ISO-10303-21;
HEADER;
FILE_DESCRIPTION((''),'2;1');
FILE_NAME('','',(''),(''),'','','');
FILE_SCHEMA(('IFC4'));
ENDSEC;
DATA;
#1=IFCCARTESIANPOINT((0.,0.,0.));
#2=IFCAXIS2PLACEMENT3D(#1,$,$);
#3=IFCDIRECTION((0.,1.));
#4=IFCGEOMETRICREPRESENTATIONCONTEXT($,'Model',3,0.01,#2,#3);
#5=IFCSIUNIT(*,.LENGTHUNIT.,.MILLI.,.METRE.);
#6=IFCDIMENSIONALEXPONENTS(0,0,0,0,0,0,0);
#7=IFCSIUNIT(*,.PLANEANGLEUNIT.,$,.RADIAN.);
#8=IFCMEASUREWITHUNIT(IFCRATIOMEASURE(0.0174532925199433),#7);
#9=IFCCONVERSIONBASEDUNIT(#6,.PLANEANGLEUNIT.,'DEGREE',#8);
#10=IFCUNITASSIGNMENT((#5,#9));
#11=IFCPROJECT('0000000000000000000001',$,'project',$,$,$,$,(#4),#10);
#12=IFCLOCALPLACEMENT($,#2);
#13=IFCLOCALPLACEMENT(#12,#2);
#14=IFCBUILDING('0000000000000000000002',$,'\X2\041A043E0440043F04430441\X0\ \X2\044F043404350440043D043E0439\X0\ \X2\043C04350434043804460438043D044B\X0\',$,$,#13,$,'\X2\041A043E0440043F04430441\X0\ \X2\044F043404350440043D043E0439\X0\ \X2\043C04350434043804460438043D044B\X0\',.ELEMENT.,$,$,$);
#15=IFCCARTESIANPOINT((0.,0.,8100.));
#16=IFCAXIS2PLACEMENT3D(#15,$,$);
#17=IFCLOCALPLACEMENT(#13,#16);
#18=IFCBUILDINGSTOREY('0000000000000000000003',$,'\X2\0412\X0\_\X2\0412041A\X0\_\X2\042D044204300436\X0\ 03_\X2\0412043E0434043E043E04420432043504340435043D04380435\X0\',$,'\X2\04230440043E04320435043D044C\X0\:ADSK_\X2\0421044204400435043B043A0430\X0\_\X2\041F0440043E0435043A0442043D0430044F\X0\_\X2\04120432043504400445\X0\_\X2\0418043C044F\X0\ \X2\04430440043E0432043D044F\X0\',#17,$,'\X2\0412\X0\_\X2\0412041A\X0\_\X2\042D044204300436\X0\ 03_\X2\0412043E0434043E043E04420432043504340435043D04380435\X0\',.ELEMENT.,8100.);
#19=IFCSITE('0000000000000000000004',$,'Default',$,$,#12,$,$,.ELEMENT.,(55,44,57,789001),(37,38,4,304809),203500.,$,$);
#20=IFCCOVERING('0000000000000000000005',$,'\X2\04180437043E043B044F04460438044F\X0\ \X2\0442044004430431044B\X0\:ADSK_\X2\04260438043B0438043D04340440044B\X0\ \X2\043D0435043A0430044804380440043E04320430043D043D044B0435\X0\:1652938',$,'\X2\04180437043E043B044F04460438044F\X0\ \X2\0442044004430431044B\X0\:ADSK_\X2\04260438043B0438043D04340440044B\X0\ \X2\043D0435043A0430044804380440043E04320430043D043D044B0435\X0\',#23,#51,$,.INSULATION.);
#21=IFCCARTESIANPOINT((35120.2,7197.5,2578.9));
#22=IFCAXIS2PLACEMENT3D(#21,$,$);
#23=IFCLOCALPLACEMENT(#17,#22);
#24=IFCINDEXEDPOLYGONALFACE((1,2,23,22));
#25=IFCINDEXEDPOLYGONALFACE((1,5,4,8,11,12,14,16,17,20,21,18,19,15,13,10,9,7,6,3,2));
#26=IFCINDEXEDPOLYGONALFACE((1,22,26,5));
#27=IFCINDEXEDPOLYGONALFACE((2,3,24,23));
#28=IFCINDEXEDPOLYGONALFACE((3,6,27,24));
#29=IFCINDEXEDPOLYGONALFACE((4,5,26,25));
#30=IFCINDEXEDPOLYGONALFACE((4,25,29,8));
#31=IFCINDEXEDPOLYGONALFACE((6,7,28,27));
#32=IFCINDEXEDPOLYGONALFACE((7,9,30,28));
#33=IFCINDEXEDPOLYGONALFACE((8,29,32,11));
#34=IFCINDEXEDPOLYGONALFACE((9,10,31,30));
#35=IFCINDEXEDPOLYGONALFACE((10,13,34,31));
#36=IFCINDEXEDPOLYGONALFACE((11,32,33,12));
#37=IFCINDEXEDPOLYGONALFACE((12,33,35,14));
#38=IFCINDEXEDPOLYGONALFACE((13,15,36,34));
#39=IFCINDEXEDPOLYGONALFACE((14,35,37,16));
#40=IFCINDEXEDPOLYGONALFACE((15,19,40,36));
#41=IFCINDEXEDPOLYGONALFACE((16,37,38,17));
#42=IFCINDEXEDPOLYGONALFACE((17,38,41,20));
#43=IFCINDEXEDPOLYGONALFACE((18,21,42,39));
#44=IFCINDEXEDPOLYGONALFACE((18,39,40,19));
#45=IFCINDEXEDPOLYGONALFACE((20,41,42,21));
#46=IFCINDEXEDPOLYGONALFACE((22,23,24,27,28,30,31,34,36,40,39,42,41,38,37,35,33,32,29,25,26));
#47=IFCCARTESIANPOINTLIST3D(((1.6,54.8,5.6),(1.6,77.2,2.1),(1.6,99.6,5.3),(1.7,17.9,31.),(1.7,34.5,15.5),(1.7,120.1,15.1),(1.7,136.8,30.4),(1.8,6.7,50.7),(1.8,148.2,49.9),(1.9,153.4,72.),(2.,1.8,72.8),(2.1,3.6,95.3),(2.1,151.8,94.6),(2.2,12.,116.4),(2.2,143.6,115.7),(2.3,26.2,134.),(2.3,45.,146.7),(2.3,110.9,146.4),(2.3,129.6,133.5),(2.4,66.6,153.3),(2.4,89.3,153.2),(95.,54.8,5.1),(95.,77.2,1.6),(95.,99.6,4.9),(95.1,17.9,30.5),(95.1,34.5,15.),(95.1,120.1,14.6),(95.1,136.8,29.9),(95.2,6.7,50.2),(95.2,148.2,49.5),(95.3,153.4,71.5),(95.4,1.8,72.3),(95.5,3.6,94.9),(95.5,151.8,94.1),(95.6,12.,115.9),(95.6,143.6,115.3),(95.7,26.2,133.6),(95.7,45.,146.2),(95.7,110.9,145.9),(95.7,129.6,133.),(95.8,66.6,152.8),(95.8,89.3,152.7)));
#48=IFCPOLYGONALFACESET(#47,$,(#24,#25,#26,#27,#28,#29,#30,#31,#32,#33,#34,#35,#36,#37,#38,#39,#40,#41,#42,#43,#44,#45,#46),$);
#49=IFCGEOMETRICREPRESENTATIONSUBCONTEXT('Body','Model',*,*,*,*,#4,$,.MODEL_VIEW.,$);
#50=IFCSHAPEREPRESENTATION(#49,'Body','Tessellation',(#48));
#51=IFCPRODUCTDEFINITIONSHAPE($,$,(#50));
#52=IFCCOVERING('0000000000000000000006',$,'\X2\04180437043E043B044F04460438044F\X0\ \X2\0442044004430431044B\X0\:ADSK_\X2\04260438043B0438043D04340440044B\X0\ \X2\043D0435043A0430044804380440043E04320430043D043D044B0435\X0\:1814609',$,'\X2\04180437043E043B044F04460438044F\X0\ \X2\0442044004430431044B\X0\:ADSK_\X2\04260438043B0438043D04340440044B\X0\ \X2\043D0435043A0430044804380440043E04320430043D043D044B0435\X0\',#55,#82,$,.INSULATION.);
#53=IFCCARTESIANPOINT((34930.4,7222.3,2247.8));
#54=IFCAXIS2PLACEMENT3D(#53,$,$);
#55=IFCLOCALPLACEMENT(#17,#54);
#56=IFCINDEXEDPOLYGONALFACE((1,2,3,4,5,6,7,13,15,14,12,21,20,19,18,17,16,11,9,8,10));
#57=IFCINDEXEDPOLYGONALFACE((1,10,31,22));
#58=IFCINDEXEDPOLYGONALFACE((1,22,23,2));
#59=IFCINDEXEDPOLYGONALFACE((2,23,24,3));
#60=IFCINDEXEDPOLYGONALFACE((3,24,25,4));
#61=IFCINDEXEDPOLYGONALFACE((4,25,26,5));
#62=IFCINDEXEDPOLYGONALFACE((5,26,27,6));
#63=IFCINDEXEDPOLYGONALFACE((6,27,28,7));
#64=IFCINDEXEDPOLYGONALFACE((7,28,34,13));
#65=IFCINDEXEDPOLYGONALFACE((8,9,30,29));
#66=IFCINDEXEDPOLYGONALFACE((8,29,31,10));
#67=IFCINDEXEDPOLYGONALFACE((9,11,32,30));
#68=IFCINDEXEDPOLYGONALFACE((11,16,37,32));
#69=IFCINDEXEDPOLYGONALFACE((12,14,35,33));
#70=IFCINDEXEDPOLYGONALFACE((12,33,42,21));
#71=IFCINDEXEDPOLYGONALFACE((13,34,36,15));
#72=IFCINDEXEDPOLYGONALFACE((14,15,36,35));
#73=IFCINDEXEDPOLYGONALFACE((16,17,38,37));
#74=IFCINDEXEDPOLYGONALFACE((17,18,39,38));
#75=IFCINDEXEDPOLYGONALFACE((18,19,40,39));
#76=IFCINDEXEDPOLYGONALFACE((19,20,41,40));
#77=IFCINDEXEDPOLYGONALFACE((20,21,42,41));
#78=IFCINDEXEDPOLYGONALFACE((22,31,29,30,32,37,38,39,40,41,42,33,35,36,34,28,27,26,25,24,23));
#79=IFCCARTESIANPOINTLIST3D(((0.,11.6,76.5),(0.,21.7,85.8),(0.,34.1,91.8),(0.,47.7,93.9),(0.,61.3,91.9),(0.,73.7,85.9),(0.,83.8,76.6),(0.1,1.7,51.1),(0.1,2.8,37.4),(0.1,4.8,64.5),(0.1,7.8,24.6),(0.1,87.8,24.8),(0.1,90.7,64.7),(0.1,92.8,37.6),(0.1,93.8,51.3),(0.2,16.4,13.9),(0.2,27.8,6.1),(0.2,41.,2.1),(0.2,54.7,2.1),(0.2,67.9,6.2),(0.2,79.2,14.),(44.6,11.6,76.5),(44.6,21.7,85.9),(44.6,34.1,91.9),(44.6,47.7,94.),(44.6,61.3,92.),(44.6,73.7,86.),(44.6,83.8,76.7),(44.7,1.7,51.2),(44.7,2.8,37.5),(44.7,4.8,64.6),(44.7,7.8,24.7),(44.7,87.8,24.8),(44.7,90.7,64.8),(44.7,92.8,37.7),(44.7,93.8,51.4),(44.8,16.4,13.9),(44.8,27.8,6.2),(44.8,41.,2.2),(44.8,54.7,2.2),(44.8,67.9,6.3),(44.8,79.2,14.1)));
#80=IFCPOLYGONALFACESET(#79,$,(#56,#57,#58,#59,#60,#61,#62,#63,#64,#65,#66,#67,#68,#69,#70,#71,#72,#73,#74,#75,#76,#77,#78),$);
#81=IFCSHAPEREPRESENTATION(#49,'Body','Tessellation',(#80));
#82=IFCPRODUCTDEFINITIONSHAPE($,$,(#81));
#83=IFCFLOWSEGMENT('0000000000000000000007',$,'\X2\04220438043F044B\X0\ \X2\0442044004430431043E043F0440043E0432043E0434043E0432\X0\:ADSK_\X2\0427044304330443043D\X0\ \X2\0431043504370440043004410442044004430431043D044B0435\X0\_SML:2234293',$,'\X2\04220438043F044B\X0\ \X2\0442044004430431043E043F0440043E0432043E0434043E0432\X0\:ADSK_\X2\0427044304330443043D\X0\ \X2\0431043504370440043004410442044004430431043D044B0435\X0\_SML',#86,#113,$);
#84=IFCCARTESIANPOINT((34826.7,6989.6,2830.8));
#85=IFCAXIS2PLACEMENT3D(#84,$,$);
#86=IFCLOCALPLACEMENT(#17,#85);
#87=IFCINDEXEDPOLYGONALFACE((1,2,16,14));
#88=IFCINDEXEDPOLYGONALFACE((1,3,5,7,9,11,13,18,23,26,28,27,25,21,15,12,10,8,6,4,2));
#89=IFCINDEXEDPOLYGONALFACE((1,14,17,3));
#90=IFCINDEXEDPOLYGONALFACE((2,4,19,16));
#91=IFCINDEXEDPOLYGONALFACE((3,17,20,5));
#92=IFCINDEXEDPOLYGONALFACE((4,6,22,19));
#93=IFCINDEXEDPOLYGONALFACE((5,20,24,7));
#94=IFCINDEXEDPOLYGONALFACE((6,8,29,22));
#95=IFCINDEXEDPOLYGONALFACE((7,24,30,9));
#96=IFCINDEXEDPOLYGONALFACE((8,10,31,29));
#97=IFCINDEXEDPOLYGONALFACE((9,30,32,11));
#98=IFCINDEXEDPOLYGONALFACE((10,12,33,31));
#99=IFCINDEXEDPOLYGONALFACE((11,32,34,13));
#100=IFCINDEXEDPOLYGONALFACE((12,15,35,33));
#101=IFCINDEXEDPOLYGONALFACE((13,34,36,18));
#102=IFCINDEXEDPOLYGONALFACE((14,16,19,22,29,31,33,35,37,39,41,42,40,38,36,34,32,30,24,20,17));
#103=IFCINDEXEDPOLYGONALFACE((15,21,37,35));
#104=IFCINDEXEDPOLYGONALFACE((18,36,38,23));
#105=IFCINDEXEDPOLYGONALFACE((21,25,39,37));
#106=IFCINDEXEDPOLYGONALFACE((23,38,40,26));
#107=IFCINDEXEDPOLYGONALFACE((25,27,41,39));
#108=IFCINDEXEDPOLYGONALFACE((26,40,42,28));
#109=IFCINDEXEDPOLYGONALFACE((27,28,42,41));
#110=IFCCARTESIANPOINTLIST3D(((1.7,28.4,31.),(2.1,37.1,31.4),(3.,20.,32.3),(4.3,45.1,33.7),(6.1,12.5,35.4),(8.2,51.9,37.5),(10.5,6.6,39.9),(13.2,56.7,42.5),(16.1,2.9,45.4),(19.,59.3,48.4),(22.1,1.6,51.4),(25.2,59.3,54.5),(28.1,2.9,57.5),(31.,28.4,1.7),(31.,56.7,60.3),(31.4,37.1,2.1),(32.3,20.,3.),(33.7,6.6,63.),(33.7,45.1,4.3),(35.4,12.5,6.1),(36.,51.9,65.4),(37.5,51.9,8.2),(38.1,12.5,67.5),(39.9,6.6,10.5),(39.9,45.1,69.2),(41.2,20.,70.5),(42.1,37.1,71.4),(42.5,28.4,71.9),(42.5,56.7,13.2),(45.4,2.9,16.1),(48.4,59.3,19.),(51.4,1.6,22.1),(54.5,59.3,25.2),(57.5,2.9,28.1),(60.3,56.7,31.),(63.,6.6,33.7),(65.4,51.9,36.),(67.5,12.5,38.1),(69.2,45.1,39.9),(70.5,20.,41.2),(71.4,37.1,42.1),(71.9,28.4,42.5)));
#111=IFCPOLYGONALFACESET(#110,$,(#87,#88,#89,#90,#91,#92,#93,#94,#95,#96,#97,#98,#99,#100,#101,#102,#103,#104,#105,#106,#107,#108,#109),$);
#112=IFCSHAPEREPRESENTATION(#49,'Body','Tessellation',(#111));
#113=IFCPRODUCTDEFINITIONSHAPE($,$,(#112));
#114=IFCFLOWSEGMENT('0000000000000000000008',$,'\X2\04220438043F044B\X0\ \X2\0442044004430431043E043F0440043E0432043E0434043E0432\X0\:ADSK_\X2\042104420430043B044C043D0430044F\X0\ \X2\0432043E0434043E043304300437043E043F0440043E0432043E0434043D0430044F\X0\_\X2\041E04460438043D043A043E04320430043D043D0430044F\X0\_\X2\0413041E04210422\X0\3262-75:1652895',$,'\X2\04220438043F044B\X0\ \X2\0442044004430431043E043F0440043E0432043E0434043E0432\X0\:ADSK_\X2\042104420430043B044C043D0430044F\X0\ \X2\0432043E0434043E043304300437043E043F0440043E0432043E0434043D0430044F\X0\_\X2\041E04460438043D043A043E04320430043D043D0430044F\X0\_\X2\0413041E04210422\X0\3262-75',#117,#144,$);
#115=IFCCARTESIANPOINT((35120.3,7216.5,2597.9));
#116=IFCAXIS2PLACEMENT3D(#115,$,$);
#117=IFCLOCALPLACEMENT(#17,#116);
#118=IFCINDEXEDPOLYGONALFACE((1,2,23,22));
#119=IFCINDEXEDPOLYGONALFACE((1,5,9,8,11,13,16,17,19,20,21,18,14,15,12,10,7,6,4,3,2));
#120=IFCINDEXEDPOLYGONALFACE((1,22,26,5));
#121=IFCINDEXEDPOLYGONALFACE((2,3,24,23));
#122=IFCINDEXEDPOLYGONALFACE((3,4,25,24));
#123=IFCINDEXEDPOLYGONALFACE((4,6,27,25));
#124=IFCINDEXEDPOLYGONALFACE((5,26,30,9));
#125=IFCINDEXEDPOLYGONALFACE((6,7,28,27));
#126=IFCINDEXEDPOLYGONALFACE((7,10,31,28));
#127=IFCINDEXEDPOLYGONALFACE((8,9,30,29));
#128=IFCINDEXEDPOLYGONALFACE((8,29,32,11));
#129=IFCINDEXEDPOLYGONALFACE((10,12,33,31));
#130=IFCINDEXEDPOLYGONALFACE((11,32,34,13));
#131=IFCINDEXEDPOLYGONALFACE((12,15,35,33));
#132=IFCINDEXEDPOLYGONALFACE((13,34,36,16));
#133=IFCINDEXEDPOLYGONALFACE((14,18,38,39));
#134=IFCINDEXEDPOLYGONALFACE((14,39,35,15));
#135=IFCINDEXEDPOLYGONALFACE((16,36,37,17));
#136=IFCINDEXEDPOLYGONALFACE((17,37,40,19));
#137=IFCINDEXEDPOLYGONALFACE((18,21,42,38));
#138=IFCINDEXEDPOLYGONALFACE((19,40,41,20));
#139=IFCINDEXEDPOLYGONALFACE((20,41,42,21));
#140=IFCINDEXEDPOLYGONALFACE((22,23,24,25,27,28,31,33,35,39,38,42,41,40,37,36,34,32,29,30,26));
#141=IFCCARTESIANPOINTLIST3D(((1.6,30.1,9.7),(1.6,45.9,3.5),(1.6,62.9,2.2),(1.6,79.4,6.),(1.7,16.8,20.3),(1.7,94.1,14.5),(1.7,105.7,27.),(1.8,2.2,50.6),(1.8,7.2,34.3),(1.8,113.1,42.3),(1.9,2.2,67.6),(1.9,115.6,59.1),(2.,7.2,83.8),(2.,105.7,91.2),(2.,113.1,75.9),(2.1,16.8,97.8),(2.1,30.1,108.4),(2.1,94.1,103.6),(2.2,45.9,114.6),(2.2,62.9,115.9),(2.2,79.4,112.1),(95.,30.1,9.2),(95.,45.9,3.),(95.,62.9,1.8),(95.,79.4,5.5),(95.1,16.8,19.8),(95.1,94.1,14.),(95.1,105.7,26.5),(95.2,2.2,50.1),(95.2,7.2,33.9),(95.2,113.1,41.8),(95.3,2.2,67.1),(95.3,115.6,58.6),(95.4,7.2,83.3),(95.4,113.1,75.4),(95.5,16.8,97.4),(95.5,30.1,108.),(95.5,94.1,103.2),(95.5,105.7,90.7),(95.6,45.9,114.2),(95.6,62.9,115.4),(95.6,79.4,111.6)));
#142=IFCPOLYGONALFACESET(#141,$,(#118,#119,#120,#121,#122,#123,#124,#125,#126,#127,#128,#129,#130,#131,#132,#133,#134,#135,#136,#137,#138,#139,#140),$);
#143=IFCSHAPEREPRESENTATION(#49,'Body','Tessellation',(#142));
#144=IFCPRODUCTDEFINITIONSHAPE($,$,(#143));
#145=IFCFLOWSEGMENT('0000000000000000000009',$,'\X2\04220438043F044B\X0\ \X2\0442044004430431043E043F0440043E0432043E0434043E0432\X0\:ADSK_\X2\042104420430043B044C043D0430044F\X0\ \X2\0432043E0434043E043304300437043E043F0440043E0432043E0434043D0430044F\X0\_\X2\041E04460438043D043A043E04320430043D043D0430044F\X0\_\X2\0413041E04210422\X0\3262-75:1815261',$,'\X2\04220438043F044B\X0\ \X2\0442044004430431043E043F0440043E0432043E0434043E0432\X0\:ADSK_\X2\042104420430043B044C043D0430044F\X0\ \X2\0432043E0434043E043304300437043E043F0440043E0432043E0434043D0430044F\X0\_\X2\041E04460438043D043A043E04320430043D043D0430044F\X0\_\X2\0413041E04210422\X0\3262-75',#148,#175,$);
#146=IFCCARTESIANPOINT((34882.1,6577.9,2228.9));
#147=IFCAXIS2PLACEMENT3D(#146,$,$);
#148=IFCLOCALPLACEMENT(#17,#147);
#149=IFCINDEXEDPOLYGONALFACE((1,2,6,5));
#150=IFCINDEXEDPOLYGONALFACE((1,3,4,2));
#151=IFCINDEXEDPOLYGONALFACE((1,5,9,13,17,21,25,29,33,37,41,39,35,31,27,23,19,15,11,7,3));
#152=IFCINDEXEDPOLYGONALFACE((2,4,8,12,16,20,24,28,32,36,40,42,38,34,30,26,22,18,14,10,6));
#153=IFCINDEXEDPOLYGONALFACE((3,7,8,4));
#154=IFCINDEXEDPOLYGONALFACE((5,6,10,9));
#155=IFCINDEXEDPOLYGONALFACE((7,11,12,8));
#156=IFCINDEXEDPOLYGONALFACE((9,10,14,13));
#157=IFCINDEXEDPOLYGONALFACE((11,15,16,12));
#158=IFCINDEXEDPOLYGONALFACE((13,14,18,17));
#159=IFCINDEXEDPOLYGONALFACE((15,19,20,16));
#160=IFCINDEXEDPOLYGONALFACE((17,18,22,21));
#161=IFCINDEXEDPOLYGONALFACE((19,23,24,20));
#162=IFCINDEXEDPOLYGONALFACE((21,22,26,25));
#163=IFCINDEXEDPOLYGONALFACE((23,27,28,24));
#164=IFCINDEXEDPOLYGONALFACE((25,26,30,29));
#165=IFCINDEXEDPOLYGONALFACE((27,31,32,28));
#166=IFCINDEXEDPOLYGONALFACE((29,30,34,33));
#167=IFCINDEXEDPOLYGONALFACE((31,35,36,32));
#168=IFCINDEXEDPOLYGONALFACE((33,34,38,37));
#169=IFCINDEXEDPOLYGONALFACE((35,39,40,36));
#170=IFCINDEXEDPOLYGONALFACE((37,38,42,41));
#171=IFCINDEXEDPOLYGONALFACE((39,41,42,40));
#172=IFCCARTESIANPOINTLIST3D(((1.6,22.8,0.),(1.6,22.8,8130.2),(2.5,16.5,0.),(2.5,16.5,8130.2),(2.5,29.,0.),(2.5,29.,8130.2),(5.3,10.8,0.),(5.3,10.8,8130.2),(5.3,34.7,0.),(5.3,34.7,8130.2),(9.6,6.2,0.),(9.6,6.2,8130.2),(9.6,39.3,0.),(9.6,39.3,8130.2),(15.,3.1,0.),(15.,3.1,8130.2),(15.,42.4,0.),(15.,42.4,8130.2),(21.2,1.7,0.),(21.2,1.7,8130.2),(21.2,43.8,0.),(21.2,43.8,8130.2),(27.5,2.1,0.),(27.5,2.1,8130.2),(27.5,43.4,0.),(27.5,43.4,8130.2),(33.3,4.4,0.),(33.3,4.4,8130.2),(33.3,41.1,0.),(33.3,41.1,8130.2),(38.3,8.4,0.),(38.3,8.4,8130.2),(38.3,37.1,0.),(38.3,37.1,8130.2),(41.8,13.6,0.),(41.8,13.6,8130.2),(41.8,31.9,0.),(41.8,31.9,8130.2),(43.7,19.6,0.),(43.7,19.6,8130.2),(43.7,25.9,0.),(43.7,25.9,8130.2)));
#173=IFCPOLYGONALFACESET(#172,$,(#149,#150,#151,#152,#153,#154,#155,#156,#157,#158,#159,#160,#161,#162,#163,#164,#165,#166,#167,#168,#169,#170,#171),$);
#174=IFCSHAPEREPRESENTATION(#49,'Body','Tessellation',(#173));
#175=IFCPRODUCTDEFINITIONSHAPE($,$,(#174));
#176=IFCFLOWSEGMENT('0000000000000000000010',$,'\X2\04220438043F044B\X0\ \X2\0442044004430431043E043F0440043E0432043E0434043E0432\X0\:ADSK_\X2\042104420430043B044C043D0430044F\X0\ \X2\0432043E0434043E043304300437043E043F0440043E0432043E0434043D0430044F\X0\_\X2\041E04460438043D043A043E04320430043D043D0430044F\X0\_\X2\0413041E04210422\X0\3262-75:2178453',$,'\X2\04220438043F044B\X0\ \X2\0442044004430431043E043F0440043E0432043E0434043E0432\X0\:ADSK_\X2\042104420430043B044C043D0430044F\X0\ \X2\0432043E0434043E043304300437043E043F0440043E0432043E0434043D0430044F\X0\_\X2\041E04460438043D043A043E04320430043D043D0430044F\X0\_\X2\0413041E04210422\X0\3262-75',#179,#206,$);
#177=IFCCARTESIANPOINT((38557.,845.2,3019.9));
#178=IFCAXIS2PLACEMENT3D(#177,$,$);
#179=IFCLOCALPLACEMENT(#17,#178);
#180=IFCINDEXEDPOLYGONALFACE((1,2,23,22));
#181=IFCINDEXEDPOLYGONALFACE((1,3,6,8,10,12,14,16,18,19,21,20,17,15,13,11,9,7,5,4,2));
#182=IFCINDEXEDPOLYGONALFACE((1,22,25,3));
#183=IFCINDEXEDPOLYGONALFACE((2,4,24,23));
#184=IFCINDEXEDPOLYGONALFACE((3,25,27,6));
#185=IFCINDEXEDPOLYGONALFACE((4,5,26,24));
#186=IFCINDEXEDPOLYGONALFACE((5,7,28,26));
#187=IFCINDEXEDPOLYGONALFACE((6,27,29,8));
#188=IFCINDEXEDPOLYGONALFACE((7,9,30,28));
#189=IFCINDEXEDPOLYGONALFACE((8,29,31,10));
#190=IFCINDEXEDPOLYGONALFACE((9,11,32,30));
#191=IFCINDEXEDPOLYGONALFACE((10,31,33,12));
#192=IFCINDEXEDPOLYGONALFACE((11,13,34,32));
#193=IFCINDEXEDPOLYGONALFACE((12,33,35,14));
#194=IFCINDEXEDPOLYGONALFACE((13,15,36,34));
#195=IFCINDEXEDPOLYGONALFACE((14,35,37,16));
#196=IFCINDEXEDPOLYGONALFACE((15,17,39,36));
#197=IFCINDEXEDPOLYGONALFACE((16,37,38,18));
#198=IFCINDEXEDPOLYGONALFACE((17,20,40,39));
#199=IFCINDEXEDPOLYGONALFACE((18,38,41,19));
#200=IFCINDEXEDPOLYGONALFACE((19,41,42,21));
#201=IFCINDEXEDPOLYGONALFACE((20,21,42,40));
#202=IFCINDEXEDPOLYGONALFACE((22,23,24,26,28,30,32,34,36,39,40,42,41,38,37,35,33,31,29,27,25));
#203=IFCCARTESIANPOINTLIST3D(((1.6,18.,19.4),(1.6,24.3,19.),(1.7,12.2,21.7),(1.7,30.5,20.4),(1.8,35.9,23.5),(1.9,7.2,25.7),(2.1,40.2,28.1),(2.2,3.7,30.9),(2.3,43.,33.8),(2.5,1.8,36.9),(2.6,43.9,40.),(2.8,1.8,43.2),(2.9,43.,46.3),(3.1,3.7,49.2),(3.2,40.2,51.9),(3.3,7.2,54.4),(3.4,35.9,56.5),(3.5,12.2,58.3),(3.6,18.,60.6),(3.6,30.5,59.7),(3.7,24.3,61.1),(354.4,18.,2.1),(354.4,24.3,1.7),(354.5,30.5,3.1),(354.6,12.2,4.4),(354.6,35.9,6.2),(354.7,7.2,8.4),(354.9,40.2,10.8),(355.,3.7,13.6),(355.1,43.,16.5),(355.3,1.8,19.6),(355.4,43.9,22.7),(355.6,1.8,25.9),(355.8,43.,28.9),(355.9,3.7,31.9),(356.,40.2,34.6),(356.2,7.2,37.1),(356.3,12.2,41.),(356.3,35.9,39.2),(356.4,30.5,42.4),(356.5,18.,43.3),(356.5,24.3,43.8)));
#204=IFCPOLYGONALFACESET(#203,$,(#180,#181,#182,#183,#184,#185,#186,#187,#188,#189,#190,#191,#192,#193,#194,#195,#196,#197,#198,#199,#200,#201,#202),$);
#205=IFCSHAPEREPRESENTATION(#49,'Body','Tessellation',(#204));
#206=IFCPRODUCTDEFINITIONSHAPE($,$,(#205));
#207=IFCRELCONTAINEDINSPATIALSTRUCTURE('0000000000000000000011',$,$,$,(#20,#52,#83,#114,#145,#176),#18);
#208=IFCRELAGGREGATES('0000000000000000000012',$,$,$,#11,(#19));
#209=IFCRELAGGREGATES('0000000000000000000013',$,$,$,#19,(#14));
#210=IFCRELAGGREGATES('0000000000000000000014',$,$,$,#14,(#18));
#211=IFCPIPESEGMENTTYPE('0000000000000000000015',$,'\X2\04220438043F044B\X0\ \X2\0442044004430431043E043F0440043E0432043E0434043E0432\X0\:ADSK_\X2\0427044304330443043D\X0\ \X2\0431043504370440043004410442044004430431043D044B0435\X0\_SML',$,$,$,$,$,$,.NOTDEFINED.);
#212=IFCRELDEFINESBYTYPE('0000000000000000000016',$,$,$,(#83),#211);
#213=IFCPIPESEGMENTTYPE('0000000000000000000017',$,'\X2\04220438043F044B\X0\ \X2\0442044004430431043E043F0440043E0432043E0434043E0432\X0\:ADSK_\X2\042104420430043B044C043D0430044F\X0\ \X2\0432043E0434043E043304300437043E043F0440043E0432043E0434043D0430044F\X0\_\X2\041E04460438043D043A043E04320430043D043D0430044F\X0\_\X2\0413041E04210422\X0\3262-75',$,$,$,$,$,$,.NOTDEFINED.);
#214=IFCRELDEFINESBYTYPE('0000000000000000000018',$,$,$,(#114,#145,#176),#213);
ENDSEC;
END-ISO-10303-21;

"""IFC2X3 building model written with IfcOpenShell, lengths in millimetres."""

from ifc_helpers import new_model, entity, si_unit, converted_unit, direction, frame, origin, origin_2d_with_axis, place, context, subcontext, project, spatial, circle, extrude, type_object, element, save


model = new_model("IFC2X3")

# Units and contexts
model_context = context("Model", 3, precision=0.01, world=origin(), true_north=direction((0.0, 1.0)))
body_context = subcontext(model_context, "Body", "Model", "MODEL_VIEW")
ifc_project = project(units=[si_unit("LENGTHUNIT", "METRE", prefix="MILLI"), converted_unit("PLANEANGLEUNIT", "DEGREE", entity("IfcRatioMeasure", 0.0174532925199433), si_unit("PLANEANGLEUNIT", "RADIAN"), dimensions=[0, 0, 0, 0, 0, 0, 0])], contexts=[model_context])

# Site, building, storey
site_placement = place(None, origin())
site = spatial("IfcSite", under=ifc_project, at=site_placement, Name="Default", CompositionType="ELEMENT", RefLatitude=(55, 44, 57, 789001), RefLongitude=(37, 38, 4, 304809), RefElevation=203500.0)
building_placement = place(site_placement, origin())
building = spatial("IfcBuilding", under=site, at=building_placement, Name="Корпус ядерной медицины", LongName="Корпус ядерной медицины", CompositionType="ELEMENT")
storey_placement = place(building_placement, frame((0.0, 0.0, 8100.0)))
storey = spatial("IfcBuildingStorey", under=building, at=storey_placement, Name="В_ВК_Этаж 03_Водоотведение", ObjectType="Уровень:ADSK_Стрелка_Проектная_Вверх_Имя уровня", LongName="В_ВК_Этаж 03_Водоотведение", CompositionType="ELEMENT", Elevation=8100.0)

# Coverings
covering_1_placement = place(storey_placement, frame((35120.2, 7197.5, 2578.9)))
element("IfcCovering", 1, at=covering_1_placement, inside=storey, Name="Изоляция трубы:ADSK_Цилиндры некашированные:1652938", ObjectType="Изоляция трубы:ADSK_Цилиндры некашированные", PredefinedType="INSULATION", context=body_context, shape_type="SweptSolid", body=[
    extrude(circle(Radius=76.0, at=origin_2d_with_axis()), frame((95.4, 77.6, 77.6), z_axis=(-0.999987, -0.000008, 0.005077), x_axis=(-0.005077, -0.005, -0.999975)), (0.0, 0.0, 1.0), 93.4),
])
covering_2_placement = place(storey_placement, frame((34930.4, 7222.3, 2247.8)))
element("IfcCovering", 2, at=covering_2_placement, inside=storey, Name="Изоляция трубы:ADSK_Цилиндры некашированные:1814609", ObjectType="Изоляция трубы:ADSK_Цилиндры некашированные", PredefinedType="INSULATION", context=body_context, shape_type="SweptSolid", body=[
    extrude(circle(Radius=46.1, at=origin_2d_with_axis()), frame((0.1, 47.8, 47.8), z_axis=(0.999998, 0.0, 0.002), x_axis=(-0.002, -0.002, 0.999996)), (0.0, 0.0, 1.0), 44.6),
])

# Flow segments
pipe_segment_type_1 = type_object("IfcPipeSegmentType", Name="Типы трубопроводов:ADSK_Чугун безраструбные_SML", PredefinedType="NOTDEFINED")
flow_segment_1_placement = place(storey_placement, frame((34826.7, 6989.6, 2830.8)))
element("IfcFlowSegment", 3, at=flow_segment_1_placement, inside=storey, type_object=pipe_segment_type_1, Name="Типы трубопроводов:ADSK_Чугун безраструбные_SML:2234293", ObjectType="Типы трубопроводов:ADSK_Чугун безраструбные_SML", context=body_context, shape_type="SweptSolid", body=[
    extrude(circle(Radius=29.0, at=origin_2d_with_axis()), frame((22.1, 30.6, 51.4), z_axis=(0.707107, 0.0, -0.707107), x_axis=(0.0, -1.0, 0.0)), (0.0, 0.0, 1.0), 41.5),
])
pipe_segment_type_2 = type_object("IfcPipeSegmentType", Name="Типы трубопроводов:ADSK_Стальная водогазопроводная_Оцинкованная_ГОСТ3262-75", PredefinedType="NOTDEFINED")
flow_segment_2_placement = place(storey_placement, frame((35120.3, 7216.5, 2597.9)))
element("IfcFlowSegment", 4, at=flow_segment_2_placement, inside=storey, type_object=pipe_segment_type_2, Name="Типы трубопроводов:ADSK_Стальная водогазопроводная_Оцинкованная_ГОСТ3262-75:1652895", ObjectType="Типы трубопроводов:ADSK_Стальная водогазопроводная_Оцинкованная_ГОСТ3262-75", context=body_context, shape_type="SweptSolid", body=[
    extrude(circle(Radius=57.0, at=origin_2d_with_axis()), frame((95.3, 58.6, 58.6), z_axis=(-0.999987, -0.000008, 0.005077), x_axis=(-0.000008, 1.0, 0.0)), (0.0, 0.0, 1.0), 93.4),
])
flow_segment_3_placement = place(storey_placement, frame((34882.1, 6577.9, 2228.9)))
element("IfcFlowSegment", 5, at=flow_segment_3_placement, inside=storey, type_object=pipe_segment_type_2, Name="Типы трубопроводов:ADSK_Стальная водогазопроводная_Оцинкованная_ГОСТ3262-75:1815261", ObjectType="Типы трубопроводов:ADSK_Стальная водогазопроводная_Оцинкованная_ГОСТ3262-75", context=body_context, shape_type="SweptSolid", body=[
    extrude(circle(Radius=21.1, at=origin_2d_with_axis()), frame((22.8, 22.8, 0.0), z_axis=(0.0, 0.0, 1.0), x_axis=(-1.0, 0.0, 0.0)), (0.0, 0.0, 1.0), 8130.2),
])
flow_segment_4_placement = place(storey_placement, frame((38557.0, 845.2, 3019.9)))
element("IfcFlowSegment", 6, at=flow_segment_4_placement, inside=storey, type_object=pipe_segment_type_2, Name="Типы трубопроводов:ADSK_Стальная водогазопроводная_Оцинкованная_ГОСТ3262-75:2178453", ObjectType="Типы трубопроводов:ADSK_Стальная водогазопроводная_Оцинкованная_ГОСТ3262-75", context=body_context, shape_type="SweptSolid", body=[
    extrude(circle(Radius=21.1, at=origin_2d_with_axis()), frame((355.4, 22.8, 22.7), z_axis=(-0.998799, 0.0, 0.048994), x_axis=(0.0, 1.0, 0.0)), (0.0, 0.0, 1.0), 353.2),
])

save(model, "model.ifc")
